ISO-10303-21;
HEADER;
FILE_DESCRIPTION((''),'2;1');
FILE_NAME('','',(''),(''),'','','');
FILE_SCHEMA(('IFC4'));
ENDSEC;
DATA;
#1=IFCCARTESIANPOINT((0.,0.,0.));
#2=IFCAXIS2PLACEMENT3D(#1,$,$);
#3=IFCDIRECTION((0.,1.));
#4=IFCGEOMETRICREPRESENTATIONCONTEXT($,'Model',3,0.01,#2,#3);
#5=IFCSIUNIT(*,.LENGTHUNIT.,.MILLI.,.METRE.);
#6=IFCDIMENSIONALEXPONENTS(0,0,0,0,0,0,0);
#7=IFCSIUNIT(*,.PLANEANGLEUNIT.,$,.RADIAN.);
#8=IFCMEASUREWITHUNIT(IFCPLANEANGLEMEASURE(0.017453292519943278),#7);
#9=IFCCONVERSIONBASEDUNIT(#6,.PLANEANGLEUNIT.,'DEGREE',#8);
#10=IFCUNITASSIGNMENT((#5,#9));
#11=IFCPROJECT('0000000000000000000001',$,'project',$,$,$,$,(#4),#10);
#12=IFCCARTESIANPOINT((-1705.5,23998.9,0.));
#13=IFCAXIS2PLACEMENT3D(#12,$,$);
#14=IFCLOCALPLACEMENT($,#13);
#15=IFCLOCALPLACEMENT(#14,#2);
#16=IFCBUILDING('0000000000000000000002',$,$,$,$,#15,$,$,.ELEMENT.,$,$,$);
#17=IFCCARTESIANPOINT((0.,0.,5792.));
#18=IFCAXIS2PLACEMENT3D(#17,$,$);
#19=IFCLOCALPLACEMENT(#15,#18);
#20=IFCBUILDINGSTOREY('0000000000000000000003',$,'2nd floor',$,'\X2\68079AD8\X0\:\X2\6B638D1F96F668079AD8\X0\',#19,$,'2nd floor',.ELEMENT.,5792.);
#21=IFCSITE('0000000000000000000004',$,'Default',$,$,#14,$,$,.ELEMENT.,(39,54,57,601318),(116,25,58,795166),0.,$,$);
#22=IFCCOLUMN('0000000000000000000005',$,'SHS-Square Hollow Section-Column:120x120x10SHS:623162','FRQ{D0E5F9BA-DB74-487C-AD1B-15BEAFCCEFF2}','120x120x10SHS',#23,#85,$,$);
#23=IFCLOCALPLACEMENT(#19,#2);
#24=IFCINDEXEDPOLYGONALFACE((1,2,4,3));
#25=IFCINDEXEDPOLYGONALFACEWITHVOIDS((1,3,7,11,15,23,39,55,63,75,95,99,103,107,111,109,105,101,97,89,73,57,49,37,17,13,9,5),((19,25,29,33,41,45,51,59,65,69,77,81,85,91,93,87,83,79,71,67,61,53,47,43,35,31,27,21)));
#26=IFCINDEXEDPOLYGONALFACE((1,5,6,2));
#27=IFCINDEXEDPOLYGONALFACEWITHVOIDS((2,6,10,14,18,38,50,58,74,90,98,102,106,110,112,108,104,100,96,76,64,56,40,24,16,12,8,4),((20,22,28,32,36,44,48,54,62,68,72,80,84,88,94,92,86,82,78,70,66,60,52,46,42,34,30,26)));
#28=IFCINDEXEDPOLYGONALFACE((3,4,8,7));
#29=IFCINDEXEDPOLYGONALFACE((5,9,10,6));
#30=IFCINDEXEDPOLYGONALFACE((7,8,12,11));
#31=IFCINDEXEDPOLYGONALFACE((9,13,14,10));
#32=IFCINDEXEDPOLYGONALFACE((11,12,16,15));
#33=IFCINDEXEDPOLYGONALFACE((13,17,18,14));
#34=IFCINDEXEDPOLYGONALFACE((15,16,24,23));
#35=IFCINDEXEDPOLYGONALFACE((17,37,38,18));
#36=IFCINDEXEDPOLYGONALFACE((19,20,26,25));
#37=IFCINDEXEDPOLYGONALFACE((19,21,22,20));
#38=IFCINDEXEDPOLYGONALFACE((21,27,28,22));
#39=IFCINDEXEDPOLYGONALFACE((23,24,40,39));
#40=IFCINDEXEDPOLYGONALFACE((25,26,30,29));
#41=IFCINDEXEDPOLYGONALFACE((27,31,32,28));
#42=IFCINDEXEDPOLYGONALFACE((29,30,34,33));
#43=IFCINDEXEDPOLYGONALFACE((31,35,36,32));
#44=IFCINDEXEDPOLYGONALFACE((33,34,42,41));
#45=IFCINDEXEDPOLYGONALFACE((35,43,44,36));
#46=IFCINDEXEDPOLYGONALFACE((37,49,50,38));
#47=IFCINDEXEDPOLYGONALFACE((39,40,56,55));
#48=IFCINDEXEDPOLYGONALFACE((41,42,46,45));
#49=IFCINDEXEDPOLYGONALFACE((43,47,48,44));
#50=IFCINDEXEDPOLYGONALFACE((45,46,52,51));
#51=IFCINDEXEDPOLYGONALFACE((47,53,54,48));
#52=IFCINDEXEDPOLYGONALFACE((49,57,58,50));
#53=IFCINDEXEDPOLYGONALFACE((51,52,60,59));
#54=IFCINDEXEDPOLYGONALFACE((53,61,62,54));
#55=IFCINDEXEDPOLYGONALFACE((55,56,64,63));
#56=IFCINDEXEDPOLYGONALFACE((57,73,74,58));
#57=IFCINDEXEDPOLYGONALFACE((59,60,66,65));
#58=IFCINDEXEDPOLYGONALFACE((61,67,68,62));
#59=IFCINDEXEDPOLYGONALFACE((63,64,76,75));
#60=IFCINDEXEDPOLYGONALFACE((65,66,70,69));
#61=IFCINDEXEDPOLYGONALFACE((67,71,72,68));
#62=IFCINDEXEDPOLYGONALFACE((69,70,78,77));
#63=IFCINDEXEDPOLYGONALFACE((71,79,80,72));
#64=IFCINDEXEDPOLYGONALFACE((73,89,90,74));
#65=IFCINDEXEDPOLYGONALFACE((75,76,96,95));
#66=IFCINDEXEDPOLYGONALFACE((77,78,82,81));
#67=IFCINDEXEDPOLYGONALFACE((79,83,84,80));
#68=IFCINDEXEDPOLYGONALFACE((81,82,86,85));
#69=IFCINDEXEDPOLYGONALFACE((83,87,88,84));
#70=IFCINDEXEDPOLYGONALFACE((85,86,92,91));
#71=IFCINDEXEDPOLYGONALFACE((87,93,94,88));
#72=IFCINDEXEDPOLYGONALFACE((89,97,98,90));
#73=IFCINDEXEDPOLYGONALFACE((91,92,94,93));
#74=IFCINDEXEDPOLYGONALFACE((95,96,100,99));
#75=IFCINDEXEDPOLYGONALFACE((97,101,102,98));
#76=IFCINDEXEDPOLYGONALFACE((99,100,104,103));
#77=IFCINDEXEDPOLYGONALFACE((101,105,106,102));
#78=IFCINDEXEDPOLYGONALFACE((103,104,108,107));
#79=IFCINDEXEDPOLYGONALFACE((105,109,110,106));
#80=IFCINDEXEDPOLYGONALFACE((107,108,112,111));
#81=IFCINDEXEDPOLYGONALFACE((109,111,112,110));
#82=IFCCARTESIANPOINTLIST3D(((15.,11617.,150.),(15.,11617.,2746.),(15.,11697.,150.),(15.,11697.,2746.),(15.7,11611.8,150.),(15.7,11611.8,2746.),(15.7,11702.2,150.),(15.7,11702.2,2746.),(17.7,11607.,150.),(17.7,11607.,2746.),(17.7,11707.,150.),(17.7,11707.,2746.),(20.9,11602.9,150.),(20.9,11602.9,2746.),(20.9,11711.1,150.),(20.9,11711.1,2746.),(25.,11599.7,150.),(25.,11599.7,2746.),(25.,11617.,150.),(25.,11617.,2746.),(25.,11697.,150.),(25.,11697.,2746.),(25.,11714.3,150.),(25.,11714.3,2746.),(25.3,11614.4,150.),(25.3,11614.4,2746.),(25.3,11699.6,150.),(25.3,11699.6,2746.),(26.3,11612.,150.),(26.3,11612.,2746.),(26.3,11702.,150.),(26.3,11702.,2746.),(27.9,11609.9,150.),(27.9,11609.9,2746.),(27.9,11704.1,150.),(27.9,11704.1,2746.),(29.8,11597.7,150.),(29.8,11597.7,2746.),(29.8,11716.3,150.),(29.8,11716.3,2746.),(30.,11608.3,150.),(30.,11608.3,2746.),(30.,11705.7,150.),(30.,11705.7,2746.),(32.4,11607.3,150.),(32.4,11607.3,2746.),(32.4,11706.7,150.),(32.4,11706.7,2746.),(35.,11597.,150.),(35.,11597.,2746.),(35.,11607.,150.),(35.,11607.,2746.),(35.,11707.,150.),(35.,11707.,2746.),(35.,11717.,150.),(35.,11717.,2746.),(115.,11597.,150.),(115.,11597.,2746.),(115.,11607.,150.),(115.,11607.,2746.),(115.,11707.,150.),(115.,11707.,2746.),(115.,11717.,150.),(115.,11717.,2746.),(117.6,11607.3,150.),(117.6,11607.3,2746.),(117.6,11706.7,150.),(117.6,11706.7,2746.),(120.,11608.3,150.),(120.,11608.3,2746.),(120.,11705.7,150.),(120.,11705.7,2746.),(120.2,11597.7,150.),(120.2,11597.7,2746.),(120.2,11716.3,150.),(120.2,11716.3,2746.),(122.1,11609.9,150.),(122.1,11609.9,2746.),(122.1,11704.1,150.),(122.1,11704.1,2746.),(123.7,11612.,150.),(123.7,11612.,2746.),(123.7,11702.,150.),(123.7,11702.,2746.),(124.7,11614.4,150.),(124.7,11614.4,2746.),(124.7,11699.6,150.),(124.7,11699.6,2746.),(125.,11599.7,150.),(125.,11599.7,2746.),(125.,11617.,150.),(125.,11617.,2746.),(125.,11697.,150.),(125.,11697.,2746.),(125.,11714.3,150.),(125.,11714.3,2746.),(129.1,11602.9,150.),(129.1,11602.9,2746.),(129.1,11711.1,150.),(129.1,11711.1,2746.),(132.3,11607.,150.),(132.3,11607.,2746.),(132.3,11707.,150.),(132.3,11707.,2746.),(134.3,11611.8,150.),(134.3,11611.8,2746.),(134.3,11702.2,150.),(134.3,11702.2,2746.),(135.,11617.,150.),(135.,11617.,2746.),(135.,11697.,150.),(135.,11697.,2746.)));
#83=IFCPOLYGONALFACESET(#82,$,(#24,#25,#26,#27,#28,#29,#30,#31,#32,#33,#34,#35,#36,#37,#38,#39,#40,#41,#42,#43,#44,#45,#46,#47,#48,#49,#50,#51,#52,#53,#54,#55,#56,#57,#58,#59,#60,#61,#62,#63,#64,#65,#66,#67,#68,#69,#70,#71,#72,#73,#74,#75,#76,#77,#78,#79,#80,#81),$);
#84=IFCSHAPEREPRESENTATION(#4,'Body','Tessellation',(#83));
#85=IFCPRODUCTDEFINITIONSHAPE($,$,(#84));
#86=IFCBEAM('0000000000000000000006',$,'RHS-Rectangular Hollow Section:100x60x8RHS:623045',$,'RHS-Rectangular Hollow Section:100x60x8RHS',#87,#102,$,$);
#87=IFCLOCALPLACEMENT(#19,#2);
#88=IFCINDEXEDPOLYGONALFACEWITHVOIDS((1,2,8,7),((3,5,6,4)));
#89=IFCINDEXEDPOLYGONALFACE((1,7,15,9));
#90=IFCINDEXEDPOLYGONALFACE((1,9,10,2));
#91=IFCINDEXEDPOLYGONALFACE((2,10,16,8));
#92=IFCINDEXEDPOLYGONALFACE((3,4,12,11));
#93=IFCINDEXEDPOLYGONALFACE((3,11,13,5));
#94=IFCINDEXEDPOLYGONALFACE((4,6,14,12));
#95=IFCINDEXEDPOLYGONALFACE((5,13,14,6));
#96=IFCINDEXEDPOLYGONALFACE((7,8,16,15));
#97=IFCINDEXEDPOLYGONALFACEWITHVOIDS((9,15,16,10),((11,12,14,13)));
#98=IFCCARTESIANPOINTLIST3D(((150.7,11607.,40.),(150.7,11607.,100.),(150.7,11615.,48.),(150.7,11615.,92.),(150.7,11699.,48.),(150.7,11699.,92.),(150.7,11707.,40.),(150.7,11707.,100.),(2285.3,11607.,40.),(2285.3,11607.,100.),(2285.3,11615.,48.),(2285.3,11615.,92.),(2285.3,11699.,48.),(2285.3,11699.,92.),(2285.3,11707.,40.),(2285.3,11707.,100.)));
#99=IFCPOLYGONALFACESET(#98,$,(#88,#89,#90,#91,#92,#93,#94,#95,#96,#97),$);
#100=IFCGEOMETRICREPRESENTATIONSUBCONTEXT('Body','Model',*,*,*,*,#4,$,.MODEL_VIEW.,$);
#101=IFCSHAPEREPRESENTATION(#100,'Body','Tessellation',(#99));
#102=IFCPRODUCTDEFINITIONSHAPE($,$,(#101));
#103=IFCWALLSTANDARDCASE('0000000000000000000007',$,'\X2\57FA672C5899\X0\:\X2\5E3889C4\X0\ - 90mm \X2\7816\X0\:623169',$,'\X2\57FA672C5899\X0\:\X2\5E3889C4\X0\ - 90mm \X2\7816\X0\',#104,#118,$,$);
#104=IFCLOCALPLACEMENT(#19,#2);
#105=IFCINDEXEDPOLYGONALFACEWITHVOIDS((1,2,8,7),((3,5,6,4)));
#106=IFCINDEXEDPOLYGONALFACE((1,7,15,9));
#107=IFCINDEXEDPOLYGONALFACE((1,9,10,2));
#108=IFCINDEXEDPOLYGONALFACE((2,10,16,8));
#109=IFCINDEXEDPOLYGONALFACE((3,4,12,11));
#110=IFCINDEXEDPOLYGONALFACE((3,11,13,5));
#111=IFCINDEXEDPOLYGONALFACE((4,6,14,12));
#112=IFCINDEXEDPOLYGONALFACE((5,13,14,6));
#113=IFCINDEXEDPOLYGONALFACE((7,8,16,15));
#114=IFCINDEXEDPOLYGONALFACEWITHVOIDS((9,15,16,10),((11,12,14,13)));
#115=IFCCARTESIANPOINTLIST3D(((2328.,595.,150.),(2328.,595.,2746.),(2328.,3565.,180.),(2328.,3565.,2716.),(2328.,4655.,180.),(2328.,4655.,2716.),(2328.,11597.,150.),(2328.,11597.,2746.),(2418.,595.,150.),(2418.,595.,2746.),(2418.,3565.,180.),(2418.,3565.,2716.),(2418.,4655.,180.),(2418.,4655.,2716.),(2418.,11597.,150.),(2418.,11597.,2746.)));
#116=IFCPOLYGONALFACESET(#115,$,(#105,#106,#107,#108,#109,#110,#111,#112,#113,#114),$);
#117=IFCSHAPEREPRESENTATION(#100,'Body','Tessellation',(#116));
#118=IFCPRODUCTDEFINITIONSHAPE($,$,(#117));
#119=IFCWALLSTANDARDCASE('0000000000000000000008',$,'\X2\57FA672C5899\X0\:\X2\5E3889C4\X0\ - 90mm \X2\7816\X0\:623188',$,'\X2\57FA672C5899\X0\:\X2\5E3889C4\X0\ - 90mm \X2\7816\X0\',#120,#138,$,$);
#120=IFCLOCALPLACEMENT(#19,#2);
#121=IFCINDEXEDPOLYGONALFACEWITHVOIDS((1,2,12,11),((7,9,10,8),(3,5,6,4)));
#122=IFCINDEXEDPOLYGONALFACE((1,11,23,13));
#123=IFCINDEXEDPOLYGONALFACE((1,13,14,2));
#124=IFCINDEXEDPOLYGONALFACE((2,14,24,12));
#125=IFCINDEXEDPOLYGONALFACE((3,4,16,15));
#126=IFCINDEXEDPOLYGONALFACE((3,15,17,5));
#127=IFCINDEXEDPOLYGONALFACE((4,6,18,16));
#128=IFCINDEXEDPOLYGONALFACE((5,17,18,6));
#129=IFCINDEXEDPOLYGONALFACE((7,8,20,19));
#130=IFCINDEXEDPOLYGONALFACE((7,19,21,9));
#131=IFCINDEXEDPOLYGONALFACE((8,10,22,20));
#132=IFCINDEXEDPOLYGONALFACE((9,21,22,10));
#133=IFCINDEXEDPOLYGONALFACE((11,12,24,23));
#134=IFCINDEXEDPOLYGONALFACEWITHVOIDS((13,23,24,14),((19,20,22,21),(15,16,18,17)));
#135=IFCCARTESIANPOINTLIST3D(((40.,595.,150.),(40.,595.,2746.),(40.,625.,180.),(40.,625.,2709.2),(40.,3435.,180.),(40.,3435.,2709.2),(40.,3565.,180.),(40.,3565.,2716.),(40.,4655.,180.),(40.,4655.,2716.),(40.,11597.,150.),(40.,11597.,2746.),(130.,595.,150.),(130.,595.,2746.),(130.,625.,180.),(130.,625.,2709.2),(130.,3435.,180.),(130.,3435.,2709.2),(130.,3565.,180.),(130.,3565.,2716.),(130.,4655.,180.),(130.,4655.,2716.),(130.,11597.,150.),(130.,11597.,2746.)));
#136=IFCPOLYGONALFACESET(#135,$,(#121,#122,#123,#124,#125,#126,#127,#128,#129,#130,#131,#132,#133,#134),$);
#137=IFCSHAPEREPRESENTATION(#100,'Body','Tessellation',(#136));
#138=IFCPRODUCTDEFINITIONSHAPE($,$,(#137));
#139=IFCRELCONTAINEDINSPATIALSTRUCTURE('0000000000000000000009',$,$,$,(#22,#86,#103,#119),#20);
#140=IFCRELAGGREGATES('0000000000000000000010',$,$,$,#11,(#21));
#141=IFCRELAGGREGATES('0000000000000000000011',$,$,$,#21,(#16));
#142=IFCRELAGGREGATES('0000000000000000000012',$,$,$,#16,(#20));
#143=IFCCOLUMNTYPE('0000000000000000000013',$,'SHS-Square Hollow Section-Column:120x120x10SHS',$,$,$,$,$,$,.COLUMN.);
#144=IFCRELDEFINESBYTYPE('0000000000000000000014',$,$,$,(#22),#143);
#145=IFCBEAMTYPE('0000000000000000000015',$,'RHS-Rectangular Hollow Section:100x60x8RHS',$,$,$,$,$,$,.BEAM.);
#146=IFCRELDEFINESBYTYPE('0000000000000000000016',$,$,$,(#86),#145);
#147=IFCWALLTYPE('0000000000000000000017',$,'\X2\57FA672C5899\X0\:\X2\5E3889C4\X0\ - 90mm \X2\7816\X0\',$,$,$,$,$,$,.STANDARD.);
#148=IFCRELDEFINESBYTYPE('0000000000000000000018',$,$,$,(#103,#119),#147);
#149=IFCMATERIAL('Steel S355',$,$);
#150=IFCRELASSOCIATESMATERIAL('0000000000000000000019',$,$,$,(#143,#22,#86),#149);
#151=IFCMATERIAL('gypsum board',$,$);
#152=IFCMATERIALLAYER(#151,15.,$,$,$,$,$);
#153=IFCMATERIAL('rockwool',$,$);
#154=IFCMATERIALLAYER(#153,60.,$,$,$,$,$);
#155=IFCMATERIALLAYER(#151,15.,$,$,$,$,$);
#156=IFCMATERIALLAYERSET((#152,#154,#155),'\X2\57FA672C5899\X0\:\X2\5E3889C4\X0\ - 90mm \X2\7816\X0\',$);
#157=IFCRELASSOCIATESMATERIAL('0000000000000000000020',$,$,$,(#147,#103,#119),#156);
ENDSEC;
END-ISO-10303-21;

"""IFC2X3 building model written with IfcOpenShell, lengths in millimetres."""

from ifc_helpers import new_model, entity, si_unit, converted_unit, direction, frame, frame_2d, origin, origin_2d, place, context, subcontext, project, spatial, rectangle, hollow_rectangle, extrude, boolean, clip, halfspace, material, layer, layer_set, layer_usage, type_object, element, save


model = new_model("IFC2X3")

# Units and contexts
model_context = context("Model", 3, precision=0.01, world=origin(), true_north=direction((0.0, 1.0)))
body_context = subcontext(model_context, "Body", "Model", "MODEL_VIEW")
ifc_project = project(units=[si_unit("LENGTHUNIT", "METRE", prefix="MILLI"), converted_unit("PLANEANGLEUNIT", "DEGREE", entity("IfcPlaneAngleMeasure", 0.017453292519943278), si_unit("PLANEANGLEUNIT", "RADIAN"), dimensions=[0, 0, 0, 0, 0, 0, 0])], contexts=[model_context])

# Site, building, storey
site_placement = place(None, frame((-1705.5, 23998.9, 0.0)))
site = spatial("IfcSite", under=ifc_project, at=site_placement, Name="Default", CompositionType="ELEMENT", RefLatitude=(39, 54, 57, 601318), RefLongitude=(116, 25, 58, 795166), RefElevation=0.0)
building_placement = place(site_placement, origin())
building = spatial("IfcBuilding", under=site, at=building_placement, CompositionType="ELEMENT")
storey_placement = place(building_placement, frame((0.0, 0.0, 5792.0)))
storey = spatial("IfcBuildingStorey", under=building, at=storey_placement, Name="2nd floor", ObjectType="标高:正负零标高", LongName="2nd floor", CompositionType="ELEMENT", Elevation=5792.0)

# Shared definitions
ifc_material_1 = material(Name="Steel S355")

# Column
column_type_1 = type_object("IfcColumnType", Name="SHS-Square Hollow Section-Column:120x120x10SHS", PredefinedType="COLUMN", material=ifc_material_1)
column_1_placement = place(storey_placement, frame((75.0, 11657.0, 2830.9), z_axis=(0.0, 0.0, 1.0), x_axis=(0.0, -1.0, 0.0)))
element("IfcColumn", 1, at=column_1_placement, inside=storey, type_object=column_type_1, material=ifc_material_1, Name="SHS-Square Hollow Section-Column:120x120x10SHS:623162", Description="FRQ{D0E5F9BA-DB74-487C-AD1B-15BEAFCCEFF2}", ObjectType="120x120x10SHS", context=model_context, shape_type="Clipping", body=[
    clip(clip(extrude(hollow_rectangle(XDim=120.0, YDim=120.0, WallThickness=10.0, InnerFilletRadius=10.0, OuterFilletRadius=20.0, at=origin_2d()), origin(), (0.0, 0.0, -1.0), 2765.7), halfspace(frame((11657.0, -75.0, -84.9), z_axis=(0.0, 0.0, -1.0), x_axis=(0.0, -1.0, 0.0)), True)), halfspace(frame((11657.0, -75.0, -2680.9), z_axis=(0.0, 0.0, 1.0), x_axis=(0.0, 1.0, 0.0)), True)),
])

# Beam
beam_type_1 = type_object("IfcBeamType", Name="RHS-Rectangular Hollow Section:100x60x8RHS", PredefinedType="BEAM")
beam_1_placement = place(storey_placement, frame((150.7, 11707.0, 70.0)))
element("IfcBeam", 2, at=beam_1_placement, inside=storey, type_object=beam_type_1, material=ifc_material_1, Name="RHS-Rectangular Hollow Section:100x60x8RHS:623045", ObjectType="RHS-Rectangular Hollow Section:100x60x8RHS", context=body_context, shape_type="SweptSolid", body=[
    boolean("DIFFERENCE", extrude(rectangle(XDim=60.0, YDim=100.0, at=frame_2d((0.0, 0.0), x_axis=(1.0, 0.0))), frame((0.0, -50.0, 0.0), z_axis=(1.0, 0.0, 0.0), x_axis=(0.0, 0.0, -1.0)), (0.0, 0.0, 1.0), 2134.6), extrude(rectangle(XDim=44.0, YDim=84.0, at=frame_2d((0.0, 0.0), x_axis=(0.0, 1.0))), frame((2134.6, -50.0, 0.0), z_axis=(-1.0, 0.0, 0.0), x_axis=(0.0, 1.0, 0.0)), (0.0, 0.0, 1.0), 2134.6)),
])

# Shared definitions
ifc_material_2 = material(Name="gypsum board")
ifc_layer_1 = layer(ifc_material_2, 15.0)
ifc_material_3 = material(Name="rockwool")
ifc_layer_2 = layer(ifc_material_3, 60.0)
ifc_layer_3 = layer(ifc_material_2, 15.0)
ifc_layer_set = layer_set([ifc_layer_1, ifc_layer_2, ifc_layer_3], Name="基本墙:常规 - 90mm 砖")
wall_type = type_object("IfcWallType", Name="基本墙:常规 - 90mm 砖", PredefinedType="STANDARD", material=ifc_layer_set)

# Wall, opening
ifc_layer_usage_1 = layer_usage(ifc_layer_set, "AXIS2", "NEGATIVE", 45.0)
wall_1_placement = place(storey_placement, frame((2373.0, 11597.0, 150.0), z_axis=(0.0, 0.0, 1.0), x_axis=(0.0, -1.0, 0.0)))
wall_1 = element("IfcWallStandardCase", 3, at=wall_1_placement, inside=storey, type_object=wall_type, material=ifc_layer_usage_1, Name="基本墙:常规 - 90mm 砖:623169", ObjectType="基本墙:常规 - 90mm 砖", context=body_context, shape_type="SweptSolid", body=[
    extrude(rectangle(XDim=11002.0, YDim=90.0, at=frame_2d((5501.0, 0.0), x_axis=(-1.0, 0.0))), origin(), (0.0, 0.0, 1.0), 2596.0),
])
opening_1_placement = place(wall_1_placement, origin())
element("IfcOpeningElement", 4, at=opening_1_placement, cuts=wall_1, ObjectType="Opening", context=body_context, shape_type="SweptSolid", body=[
    extrude(rectangle(XDim=2536.0, YDim=1090.0, at=frame_2d((0.0, 0.0), x_axis=(0.0, 1.0))), frame((7487.0, 45.0, 1298.0), z_axis=(0.0, -1.0, 0.0), x_axis=(-1.0, 0.0, 0.0)), (0.0, 0.0, 1.0), 90.0),
])

# Wall, openings
ifc_layer_usage_2 = layer_usage(ifc_layer_set, "AXIS2", "NEGATIVE", 45.0)
wall_2_placement = place(storey_placement, frame((85.0, 11597.0, 150.0), z_axis=(0.0, 0.0, 1.0), x_axis=(0.0, -1.0, 0.0)))
wall_2 = element("IfcWallStandardCase", 5, at=wall_2_placement, inside=storey, type_object=wall_type, material=ifc_layer_usage_2, Name="基本墙:常规 - 90mm 砖:623188", ObjectType="基本墙:常规 - 90mm 砖", context=body_context, shape_type="SweptSolid", body=[
    extrude(rectangle(XDim=11002.0, YDim=90.0, at=frame_2d((5501.0, 0.0), x_axis=(-1.0, 0.0))), origin(), (0.0, 0.0, 1.0), 2596.0),
])
opening_2_placement = place(wall_2_placement, origin())
element("IfcOpeningElement", 6, at=opening_2_placement, cuts=wall_2, ObjectType="Opening", context=body_context, shape_type="SweptSolid", body=[
    extrude(rectangle(XDim=2536.0, YDim=1090.0, at=frame_2d((0.0, 0.0), x_axis=(0.0, 1.0))), frame((7487.0, 45.0, 1298.0), z_axis=(0.0, -1.0, 0.0), x_axis=(-1.0, 0.0, 0.0)), (0.0, 0.0, 1.0), 90.0),
])
opening_3_placement = place(wall_2_placement, origin())
element("IfcOpeningElement", 7, at=opening_3_placement, cuts=wall_2, ObjectType="Opening", context=body_context, shape_type="SweptSolid", body=[
    extrude(rectangle(XDim=2529.2, YDim=2810.0, at=frame_2d((0.0, 0.0), x_axis=(0.0, 1.0))), frame((9567.0, 45.0, 1294.6), z_axis=(0.0, -1.0, 0.0), x_axis=(-1.0, 0.0, 0.0)), (0.0, 0.0, 1.0), 90.0),
])

save(model, "model.ifc")
